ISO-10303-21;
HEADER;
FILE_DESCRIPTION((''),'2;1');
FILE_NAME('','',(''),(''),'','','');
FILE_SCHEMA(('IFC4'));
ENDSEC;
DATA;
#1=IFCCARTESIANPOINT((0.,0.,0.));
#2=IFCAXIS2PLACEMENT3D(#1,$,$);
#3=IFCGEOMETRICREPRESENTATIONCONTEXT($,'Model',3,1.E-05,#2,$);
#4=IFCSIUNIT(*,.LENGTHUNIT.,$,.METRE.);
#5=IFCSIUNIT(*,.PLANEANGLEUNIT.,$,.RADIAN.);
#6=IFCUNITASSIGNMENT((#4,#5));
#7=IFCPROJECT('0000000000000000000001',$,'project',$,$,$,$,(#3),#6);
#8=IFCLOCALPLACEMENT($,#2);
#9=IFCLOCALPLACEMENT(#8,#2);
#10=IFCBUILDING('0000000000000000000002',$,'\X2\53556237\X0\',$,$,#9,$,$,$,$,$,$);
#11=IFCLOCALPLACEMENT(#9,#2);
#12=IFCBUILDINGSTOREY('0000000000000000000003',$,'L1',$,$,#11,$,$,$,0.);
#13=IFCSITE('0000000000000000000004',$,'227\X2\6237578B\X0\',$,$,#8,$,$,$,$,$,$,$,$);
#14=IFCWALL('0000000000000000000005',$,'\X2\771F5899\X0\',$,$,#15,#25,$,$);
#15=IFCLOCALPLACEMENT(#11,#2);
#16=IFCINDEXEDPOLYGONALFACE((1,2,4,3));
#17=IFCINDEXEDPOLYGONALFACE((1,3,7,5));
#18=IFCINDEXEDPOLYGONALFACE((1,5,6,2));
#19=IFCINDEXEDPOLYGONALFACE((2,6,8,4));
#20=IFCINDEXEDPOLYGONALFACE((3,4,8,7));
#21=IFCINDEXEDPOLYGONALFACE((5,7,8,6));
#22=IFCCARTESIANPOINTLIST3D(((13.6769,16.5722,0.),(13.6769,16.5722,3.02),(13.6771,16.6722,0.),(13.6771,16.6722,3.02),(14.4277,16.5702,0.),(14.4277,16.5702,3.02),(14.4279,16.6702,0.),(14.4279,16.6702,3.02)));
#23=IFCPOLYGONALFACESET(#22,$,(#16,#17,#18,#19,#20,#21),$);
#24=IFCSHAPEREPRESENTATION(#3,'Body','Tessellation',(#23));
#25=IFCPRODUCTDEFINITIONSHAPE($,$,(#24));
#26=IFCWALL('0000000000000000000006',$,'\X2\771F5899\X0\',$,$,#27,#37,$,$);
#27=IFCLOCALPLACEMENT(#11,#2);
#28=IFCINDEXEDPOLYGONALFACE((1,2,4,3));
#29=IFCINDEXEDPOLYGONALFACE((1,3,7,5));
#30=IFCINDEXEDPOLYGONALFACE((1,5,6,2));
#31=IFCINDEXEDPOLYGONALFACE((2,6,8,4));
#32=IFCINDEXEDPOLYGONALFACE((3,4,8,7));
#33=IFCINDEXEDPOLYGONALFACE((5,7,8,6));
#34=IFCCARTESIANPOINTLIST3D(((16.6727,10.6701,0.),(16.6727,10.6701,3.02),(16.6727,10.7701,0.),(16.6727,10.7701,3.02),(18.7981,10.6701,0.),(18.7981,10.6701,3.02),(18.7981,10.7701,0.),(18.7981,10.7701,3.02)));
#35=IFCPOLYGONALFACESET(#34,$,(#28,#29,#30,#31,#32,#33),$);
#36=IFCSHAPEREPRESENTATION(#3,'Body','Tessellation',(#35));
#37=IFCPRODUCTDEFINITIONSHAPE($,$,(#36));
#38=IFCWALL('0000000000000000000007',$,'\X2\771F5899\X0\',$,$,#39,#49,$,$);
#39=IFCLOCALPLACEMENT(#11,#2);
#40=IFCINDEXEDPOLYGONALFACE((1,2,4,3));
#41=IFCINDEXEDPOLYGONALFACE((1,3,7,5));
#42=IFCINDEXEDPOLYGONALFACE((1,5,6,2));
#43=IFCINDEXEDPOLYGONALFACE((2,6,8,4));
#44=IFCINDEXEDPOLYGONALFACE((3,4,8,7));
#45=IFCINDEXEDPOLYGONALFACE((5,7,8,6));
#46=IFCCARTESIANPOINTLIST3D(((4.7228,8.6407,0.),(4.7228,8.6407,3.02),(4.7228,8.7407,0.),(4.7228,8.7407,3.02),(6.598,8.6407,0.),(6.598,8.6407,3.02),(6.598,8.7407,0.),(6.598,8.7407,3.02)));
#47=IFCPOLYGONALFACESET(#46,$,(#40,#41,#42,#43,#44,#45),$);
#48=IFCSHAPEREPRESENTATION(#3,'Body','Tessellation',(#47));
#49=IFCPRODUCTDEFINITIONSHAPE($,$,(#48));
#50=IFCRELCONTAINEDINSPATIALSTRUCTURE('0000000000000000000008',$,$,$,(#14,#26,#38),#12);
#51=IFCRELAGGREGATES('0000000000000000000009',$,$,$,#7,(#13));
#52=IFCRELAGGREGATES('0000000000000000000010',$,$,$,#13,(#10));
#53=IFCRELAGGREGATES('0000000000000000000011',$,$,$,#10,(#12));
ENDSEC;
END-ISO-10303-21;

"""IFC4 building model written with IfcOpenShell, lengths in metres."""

from ifc_helpers import new_model, si_unit, origin, place, context, project, spatial, polyline, outline, extrude, element, save


model = new_model("IFC4")

# Units and contexts
model_context = context("Model", 3, precision=1e-05, world=origin())
ifc_project = project(units=[si_unit("LENGTHUNIT", "METRE"), si_unit("PLANEANGLEUNIT", "RADIAN")], contexts=[model_context])

# Site, building, storey
site_placement = place(None, origin())
site = spatial("IfcSite", under=ifc_project, at=site_placement, Name="227户型")
building_placement = place(site_placement, origin())
building = spatial("IfcBuilding", under=site, at=building_placement, Name="单户")
storey_placement = place(building_placement, origin())
storey = spatial("IfcBuildingStorey", under=building, at=storey_placement, Name="L1", Elevation=0.0)

# Walls
wall_1_placement = place(storey_placement, origin())
element("IfcWall", 1, at=wall_1_placement, inside=storey, Name="真墙", context=model_context, shape_type="SweptSolid", body=[
    extrude(outline(polyline([(14.4277, 16.5702), (13.6769, 16.5722), (13.6771, 16.6722), (14.4279, 16.6702), (14.4277, 16.5702)])), origin(), (0.0, 0.0, 1.0), 3.02),
])
wall_2_placement = place(storey_placement, origin())
element("IfcWall", 2, at=wall_2_placement, inside=storey, Name="真墙", context=model_context, shape_type="SweptSolid", body=[
    extrude(outline(polyline([(16.6727, 10.7701), (18.7981, 10.7701), (18.7981, 10.6701), (16.6727, 10.6701), (16.6727, 10.7701)])), origin(), (0.0, 0.0, 1.0), 3.02),
])
wall_3_placement = place(storey_placement, origin())
element("IfcWall", 3, at=wall_3_placement, inside=storey, Name="真墙", context=model_context, shape_type="SweptSolid", body=[
    extrude(outline(polyline([(4.7228, 8.7407), (6.598, 8.7407), (6.598, 8.6407), (4.7228, 8.6407), (4.7228, 8.7407)])), origin(), (0.0, 0.0, 1.0), 3.02),
])

save(model, "model.ifc")
